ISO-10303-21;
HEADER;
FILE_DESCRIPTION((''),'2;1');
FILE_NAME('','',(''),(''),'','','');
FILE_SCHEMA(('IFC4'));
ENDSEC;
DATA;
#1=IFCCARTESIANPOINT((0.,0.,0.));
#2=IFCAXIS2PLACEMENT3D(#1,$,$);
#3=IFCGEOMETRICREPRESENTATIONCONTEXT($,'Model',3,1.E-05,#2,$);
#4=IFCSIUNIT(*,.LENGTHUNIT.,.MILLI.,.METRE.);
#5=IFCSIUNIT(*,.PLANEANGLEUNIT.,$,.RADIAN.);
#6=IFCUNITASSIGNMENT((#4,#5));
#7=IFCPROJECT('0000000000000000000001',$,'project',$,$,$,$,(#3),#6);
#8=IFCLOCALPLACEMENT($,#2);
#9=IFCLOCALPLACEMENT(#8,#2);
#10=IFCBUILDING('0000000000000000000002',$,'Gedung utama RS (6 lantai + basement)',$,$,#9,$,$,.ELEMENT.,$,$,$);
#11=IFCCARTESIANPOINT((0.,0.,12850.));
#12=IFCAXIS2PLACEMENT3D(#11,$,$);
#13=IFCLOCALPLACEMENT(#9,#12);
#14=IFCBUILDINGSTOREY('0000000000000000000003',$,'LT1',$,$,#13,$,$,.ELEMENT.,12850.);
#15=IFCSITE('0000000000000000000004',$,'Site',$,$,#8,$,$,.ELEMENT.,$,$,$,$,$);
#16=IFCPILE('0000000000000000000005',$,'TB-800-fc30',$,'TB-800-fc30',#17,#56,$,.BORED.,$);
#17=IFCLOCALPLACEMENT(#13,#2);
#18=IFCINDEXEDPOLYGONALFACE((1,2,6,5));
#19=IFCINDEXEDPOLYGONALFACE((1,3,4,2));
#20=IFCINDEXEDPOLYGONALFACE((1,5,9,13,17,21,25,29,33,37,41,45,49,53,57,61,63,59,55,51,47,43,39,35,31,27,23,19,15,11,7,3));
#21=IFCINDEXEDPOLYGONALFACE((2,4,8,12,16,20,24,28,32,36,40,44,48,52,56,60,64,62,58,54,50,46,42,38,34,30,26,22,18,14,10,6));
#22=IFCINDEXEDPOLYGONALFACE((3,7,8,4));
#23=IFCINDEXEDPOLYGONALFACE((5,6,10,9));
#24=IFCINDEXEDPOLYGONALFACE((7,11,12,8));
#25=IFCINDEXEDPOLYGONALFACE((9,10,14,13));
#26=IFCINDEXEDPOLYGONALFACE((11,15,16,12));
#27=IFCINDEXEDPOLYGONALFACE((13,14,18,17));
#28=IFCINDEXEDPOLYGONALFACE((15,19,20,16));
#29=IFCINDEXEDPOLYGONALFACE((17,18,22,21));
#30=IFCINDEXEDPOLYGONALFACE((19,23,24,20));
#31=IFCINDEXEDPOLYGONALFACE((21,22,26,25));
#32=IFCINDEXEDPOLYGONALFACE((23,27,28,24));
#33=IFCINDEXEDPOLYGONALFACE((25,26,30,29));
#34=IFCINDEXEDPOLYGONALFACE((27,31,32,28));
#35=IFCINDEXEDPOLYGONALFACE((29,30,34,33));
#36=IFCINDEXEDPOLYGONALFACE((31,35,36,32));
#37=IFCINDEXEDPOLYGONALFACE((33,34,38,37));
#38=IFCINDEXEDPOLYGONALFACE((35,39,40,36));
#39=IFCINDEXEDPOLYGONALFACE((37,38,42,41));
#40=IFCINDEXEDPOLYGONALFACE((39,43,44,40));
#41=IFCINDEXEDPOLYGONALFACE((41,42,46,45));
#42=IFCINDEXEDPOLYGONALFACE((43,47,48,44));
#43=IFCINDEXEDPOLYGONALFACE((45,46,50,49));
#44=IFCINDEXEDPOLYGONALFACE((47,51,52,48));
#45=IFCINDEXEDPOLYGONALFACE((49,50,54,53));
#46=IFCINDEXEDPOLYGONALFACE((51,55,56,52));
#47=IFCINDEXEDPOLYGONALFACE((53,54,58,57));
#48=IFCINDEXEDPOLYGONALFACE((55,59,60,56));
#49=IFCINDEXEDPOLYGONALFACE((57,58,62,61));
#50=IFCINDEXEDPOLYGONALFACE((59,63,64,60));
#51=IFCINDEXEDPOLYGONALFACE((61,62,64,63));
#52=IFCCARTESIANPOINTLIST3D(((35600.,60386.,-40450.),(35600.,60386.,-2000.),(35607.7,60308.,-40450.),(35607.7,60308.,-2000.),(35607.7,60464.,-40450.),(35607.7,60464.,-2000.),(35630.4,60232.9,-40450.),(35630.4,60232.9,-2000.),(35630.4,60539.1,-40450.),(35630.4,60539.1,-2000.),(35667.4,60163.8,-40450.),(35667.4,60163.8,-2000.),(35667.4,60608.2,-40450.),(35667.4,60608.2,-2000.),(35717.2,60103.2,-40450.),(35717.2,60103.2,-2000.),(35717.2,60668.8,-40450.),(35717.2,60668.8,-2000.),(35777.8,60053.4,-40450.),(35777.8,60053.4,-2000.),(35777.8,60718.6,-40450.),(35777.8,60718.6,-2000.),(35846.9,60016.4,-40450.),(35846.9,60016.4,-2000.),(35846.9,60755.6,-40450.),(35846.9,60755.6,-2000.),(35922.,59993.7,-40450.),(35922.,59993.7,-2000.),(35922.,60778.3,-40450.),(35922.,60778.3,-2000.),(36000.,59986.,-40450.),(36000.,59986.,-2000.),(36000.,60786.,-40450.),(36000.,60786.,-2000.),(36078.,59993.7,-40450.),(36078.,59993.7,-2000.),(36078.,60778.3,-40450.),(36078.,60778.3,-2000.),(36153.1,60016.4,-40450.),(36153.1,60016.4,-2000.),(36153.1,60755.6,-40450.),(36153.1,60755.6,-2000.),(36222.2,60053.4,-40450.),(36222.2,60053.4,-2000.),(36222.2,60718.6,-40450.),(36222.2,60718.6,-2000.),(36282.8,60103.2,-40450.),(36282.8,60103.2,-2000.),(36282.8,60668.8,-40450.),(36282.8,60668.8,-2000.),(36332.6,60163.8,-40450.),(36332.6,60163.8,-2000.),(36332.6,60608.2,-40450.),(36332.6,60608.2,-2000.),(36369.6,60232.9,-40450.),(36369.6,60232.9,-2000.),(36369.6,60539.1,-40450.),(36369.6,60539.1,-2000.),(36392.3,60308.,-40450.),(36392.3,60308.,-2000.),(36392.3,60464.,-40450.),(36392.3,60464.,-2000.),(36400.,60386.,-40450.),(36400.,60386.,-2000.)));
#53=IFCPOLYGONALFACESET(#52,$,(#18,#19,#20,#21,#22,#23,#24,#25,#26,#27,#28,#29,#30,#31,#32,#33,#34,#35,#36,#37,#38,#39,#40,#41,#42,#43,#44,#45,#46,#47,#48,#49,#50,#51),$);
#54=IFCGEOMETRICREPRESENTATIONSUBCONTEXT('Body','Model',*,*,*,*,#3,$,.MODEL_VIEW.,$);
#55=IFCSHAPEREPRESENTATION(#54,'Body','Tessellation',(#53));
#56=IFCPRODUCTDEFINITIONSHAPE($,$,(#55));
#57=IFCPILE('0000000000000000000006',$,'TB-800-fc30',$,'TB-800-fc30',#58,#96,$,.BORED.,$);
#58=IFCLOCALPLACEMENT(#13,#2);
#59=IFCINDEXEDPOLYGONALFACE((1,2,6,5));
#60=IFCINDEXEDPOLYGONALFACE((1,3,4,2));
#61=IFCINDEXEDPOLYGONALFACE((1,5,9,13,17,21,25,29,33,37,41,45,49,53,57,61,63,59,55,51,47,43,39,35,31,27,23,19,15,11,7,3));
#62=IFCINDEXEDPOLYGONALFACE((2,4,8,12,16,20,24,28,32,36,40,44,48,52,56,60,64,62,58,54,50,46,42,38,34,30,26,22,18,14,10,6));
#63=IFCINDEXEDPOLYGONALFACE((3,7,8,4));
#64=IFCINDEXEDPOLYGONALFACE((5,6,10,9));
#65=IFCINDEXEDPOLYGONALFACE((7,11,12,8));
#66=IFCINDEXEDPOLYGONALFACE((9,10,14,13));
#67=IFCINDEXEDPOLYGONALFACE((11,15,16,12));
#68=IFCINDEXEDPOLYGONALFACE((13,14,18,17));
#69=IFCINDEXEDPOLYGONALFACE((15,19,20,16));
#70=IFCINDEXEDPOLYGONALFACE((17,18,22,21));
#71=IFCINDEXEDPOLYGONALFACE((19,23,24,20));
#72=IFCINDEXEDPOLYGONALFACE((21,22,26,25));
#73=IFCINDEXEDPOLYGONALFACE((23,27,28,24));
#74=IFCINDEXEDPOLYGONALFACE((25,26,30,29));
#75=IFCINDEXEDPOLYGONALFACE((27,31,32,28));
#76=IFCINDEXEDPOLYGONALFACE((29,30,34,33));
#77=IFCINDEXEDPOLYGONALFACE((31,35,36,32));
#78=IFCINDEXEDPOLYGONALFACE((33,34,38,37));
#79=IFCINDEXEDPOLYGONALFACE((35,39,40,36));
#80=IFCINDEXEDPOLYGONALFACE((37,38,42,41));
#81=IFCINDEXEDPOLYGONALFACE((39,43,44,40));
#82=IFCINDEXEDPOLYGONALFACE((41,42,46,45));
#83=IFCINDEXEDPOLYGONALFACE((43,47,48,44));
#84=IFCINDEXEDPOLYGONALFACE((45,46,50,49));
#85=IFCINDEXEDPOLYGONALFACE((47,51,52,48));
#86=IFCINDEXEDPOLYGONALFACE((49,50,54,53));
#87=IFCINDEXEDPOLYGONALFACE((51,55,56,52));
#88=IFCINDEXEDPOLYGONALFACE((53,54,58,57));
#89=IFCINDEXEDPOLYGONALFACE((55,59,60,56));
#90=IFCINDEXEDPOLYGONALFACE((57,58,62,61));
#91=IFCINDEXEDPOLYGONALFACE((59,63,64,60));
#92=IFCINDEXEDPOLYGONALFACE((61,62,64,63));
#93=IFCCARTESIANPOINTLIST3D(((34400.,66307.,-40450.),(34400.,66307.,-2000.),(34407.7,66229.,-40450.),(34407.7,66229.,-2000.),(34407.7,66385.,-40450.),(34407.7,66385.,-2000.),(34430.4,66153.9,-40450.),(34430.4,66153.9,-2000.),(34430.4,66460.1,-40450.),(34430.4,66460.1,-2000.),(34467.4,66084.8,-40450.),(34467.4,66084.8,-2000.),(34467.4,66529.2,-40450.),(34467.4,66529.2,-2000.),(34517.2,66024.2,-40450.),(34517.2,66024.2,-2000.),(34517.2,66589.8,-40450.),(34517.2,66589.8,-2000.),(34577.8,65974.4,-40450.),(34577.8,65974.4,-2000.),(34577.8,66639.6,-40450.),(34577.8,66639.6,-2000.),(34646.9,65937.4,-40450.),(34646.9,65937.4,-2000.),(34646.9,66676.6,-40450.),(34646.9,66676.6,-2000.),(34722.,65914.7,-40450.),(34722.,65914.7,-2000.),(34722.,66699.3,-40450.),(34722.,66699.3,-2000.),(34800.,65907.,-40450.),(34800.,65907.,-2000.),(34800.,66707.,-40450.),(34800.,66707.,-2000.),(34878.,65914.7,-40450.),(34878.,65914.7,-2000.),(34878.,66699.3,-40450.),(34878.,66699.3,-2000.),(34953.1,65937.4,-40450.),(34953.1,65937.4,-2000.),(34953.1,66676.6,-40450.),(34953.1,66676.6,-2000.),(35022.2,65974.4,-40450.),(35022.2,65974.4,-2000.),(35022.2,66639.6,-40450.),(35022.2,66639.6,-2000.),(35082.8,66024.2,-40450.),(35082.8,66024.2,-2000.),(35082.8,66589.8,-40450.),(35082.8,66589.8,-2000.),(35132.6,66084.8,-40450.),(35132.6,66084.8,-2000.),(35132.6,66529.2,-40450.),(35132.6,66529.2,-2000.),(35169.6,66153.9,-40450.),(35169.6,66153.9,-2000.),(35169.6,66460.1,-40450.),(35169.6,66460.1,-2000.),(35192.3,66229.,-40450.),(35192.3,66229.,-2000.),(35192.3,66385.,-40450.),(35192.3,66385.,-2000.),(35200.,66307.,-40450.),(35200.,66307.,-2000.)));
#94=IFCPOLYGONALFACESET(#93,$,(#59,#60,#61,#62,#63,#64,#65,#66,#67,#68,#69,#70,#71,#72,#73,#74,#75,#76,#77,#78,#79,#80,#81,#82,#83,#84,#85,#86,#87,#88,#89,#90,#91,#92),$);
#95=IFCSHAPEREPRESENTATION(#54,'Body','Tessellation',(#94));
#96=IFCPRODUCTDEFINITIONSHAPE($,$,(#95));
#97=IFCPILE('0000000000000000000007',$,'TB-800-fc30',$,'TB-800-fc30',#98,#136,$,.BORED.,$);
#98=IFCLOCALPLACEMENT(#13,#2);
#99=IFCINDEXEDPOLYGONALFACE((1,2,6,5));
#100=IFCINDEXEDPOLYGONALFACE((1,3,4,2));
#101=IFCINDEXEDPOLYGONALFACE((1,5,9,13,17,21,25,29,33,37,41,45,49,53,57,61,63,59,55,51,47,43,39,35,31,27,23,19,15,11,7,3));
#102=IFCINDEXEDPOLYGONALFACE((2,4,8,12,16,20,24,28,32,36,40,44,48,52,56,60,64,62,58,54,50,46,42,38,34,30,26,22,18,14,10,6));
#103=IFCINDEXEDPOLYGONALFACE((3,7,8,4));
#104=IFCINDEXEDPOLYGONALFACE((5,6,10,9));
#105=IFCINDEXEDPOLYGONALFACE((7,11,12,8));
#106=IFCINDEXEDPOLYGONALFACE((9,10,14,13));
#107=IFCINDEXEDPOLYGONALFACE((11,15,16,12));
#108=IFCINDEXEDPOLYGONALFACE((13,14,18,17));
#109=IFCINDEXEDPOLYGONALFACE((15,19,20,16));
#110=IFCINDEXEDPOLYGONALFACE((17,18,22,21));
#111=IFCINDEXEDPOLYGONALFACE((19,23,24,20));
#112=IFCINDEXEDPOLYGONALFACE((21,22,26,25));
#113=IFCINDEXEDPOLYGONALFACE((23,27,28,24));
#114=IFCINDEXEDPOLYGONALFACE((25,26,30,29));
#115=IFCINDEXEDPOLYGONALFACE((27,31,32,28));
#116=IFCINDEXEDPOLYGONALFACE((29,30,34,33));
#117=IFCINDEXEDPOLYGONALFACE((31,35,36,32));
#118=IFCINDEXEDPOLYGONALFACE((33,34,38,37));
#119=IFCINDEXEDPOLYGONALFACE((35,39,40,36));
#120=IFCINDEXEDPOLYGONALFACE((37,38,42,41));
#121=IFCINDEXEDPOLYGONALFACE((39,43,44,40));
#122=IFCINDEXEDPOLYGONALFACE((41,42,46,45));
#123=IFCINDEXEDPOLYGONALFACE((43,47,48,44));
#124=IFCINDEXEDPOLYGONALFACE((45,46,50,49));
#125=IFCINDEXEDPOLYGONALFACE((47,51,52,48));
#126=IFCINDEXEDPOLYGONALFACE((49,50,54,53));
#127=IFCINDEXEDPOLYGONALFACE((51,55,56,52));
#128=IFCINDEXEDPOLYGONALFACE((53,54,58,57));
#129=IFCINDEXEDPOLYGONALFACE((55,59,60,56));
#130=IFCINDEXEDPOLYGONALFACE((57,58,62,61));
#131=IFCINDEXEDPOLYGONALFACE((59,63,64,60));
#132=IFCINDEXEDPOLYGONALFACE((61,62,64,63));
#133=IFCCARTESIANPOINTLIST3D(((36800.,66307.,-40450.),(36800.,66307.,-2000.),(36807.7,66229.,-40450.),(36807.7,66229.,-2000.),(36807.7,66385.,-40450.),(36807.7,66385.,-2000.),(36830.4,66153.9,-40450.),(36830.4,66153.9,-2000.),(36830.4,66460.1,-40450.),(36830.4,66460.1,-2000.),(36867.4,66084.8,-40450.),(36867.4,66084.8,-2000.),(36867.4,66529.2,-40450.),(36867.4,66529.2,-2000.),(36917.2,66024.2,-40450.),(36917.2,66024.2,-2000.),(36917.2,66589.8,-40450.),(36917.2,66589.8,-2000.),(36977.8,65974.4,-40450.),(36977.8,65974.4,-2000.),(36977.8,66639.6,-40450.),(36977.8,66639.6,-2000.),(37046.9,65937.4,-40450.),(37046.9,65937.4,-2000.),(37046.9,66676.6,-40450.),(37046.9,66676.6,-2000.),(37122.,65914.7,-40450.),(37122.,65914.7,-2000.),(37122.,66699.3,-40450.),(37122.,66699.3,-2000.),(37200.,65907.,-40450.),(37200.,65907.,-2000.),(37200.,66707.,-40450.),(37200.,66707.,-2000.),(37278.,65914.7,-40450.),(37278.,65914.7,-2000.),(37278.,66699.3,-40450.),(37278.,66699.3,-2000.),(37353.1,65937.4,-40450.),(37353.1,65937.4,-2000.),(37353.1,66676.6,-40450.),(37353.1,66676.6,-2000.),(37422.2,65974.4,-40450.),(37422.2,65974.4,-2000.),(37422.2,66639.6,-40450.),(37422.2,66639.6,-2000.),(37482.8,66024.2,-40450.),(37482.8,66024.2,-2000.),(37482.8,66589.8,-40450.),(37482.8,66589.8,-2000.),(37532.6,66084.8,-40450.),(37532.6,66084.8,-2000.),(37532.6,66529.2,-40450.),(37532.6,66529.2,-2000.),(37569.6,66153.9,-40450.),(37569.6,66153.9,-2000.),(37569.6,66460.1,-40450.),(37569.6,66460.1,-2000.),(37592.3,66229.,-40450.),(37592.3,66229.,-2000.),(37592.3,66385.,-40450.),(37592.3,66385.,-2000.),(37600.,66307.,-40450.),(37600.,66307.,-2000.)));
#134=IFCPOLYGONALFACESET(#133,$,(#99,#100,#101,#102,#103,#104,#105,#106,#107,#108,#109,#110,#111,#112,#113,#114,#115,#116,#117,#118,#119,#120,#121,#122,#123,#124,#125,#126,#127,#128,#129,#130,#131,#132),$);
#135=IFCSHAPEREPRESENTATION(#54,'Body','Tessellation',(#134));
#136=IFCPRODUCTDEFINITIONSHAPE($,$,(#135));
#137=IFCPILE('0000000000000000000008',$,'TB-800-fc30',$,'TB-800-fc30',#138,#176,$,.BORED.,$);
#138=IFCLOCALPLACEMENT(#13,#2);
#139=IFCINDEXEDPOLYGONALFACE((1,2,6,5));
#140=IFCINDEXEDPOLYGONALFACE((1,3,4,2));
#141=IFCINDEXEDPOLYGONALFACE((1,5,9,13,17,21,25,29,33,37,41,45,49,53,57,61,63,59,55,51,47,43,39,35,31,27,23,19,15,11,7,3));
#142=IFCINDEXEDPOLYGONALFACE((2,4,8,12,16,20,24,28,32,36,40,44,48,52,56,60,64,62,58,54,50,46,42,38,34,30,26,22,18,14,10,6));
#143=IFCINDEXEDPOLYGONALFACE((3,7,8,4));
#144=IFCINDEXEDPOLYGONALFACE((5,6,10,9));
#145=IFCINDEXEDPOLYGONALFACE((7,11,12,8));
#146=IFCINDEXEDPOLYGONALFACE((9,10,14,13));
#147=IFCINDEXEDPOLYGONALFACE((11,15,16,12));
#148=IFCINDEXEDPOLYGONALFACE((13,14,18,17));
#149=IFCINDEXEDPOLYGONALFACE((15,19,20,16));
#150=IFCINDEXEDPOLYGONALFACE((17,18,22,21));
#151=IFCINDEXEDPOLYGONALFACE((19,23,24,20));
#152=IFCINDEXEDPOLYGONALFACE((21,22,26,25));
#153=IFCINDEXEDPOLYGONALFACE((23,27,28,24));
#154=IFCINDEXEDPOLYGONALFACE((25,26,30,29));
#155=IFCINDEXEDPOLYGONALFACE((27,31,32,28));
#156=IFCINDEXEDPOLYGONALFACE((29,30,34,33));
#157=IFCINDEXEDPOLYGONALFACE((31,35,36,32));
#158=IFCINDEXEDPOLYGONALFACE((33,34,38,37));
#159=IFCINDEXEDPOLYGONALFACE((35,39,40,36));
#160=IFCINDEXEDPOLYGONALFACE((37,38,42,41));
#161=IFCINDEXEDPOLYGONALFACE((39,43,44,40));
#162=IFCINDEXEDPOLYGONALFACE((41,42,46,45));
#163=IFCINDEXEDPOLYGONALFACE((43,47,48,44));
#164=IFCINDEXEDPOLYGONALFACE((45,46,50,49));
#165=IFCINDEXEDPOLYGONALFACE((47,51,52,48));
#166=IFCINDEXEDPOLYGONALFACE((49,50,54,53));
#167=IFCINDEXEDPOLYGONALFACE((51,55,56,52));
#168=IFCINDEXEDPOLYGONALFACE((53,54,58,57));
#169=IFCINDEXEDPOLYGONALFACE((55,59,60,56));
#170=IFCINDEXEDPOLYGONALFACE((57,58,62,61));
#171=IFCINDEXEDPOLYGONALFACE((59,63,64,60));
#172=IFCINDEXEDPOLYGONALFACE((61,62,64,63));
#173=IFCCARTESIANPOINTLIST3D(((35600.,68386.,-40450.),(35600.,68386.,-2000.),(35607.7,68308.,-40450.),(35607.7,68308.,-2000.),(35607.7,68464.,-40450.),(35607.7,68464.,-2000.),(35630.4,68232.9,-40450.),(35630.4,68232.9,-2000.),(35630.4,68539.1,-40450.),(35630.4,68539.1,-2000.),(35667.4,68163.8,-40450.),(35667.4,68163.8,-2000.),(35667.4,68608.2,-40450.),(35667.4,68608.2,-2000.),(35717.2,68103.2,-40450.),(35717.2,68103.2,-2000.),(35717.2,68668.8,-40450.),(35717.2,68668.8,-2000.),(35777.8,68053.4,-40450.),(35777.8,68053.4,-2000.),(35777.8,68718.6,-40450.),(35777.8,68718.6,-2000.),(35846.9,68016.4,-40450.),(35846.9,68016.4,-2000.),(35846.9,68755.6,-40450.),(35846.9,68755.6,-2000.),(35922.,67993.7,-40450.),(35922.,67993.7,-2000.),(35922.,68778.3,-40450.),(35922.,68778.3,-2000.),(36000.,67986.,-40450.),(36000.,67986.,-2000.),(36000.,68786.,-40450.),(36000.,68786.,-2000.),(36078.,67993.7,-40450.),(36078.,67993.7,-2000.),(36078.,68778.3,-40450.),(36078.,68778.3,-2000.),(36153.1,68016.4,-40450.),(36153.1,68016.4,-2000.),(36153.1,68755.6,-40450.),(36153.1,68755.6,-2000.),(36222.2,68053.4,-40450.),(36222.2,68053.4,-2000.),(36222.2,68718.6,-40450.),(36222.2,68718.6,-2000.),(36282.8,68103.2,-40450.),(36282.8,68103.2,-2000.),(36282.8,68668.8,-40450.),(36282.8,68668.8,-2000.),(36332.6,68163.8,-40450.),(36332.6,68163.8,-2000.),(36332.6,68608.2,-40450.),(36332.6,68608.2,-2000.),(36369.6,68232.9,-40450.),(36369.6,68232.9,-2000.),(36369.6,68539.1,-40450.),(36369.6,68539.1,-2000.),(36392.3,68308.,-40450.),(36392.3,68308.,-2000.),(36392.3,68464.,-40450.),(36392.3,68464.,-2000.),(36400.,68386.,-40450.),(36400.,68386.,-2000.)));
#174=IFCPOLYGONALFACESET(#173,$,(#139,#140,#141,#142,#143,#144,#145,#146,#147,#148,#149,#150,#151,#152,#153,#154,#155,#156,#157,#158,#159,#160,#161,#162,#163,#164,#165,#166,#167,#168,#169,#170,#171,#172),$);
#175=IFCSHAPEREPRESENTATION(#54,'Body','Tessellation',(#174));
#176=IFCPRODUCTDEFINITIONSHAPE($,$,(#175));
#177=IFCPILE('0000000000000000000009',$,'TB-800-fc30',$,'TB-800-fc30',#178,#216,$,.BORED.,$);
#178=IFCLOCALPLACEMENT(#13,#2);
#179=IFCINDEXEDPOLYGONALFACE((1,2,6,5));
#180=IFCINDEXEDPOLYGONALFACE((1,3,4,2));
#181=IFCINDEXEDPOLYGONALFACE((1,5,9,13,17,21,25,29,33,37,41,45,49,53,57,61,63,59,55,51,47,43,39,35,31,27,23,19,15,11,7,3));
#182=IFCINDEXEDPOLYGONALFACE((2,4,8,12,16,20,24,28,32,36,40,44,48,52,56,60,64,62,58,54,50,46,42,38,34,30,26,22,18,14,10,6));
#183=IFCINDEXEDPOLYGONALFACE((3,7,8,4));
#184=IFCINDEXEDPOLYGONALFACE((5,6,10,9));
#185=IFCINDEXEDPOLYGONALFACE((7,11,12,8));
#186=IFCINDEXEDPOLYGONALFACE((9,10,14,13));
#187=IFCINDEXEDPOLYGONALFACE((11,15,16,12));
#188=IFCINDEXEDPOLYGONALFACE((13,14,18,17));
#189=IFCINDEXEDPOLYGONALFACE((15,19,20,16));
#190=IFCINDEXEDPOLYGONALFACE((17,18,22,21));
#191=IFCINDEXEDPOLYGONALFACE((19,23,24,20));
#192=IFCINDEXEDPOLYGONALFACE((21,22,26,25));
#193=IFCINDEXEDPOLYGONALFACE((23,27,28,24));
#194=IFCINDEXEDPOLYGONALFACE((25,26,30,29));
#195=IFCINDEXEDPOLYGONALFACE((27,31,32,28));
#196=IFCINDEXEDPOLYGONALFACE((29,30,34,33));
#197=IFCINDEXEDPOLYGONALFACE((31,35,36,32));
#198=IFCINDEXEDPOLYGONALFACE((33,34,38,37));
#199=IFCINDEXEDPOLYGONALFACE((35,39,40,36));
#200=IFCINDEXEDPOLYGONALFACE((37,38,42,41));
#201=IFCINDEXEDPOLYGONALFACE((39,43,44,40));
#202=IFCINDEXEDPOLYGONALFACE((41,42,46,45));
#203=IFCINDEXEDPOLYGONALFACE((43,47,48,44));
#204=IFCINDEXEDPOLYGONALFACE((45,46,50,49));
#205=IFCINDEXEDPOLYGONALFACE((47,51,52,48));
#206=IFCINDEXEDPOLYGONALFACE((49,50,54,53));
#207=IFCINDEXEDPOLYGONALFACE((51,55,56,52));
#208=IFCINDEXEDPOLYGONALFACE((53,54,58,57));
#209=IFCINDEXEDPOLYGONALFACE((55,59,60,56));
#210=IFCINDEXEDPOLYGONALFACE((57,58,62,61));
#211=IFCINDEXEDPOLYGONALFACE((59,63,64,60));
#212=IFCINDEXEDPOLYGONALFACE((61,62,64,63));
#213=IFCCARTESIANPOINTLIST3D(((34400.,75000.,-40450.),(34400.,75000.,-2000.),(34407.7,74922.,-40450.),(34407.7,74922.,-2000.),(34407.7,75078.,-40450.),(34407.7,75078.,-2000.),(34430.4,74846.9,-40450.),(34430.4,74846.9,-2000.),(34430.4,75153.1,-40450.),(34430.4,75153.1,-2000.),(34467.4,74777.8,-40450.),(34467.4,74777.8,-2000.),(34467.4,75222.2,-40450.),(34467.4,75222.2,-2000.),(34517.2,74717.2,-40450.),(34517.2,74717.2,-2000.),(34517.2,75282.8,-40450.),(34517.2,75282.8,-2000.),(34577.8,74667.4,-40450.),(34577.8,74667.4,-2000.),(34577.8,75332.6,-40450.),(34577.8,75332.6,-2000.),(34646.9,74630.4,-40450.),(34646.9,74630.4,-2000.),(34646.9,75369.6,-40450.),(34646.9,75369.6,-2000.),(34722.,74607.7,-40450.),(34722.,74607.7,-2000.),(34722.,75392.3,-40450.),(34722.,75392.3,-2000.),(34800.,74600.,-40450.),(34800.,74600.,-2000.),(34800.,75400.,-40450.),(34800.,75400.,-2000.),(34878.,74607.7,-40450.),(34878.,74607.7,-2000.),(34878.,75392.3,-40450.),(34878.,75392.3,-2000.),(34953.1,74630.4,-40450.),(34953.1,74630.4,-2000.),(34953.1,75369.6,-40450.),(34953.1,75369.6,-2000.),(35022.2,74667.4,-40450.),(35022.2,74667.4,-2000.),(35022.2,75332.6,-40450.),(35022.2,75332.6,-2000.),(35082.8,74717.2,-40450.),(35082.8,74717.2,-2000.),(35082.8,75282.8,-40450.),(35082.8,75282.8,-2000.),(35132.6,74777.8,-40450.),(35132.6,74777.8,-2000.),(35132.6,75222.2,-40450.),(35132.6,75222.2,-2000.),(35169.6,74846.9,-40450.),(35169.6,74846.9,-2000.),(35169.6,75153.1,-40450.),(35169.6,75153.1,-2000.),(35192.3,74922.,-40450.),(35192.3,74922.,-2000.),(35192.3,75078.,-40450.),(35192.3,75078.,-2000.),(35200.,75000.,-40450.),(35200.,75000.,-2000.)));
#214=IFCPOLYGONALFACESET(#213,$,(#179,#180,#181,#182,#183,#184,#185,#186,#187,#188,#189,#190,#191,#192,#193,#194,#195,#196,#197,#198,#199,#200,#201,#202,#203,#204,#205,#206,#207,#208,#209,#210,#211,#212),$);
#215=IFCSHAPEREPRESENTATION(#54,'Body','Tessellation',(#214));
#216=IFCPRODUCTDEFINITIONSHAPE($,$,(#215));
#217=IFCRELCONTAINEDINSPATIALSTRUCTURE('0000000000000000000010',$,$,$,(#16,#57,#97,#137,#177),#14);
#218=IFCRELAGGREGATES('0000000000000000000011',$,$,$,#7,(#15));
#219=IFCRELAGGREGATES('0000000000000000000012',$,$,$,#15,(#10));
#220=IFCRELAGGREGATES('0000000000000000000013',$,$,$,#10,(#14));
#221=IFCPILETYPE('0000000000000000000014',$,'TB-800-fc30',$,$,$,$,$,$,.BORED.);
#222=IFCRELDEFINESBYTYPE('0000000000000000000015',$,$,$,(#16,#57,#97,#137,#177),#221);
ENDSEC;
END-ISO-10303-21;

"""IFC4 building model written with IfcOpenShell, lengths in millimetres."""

from ifc_helpers import new_model, si_unit, frame, origin, origin_2d, place, context, subcontext, project, spatial, circle, extrude, material_profile, profile_set, profile_usage, type_object, element, save


model = new_model("IFC4")

# Units and contexts
model_context = context("Model", 3, precision=1e-05, world=origin())
body_context = subcontext(model_context, "Body", "Model", "MODEL_VIEW")
ifc_project = project(units=[si_unit("LENGTHUNIT", "METRE", prefix="MILLI"), si_unit("PLANEANGLEUNIT", "RADIAN")], contexts=[model_context])

# Site, building, storey
site_placement = place(None, origin())
site = spatial("IfcSite", under=ifc_project, at=site_placement, Name="Site", CompositionType="ELEMENT")
building_placement = place(site_placement, origin())
building = spatial("IfcBuilding", under=site, at=building_placement, Name="Gedung utama RS (6 lantai + basement)", CompositionType="ELEMENT")
storey_placement = place(building_placement, frame((0.0, 0.0, 12850.0)))
storey = spatial("IfcBuildingStorey", under=building, at=storey_placement, Name="LT1", CompositionType="ELEMENT", Elevation=12850.0)

# Piles
ifc_material_profile = material_profile(None, circle(Radius=400.0, at=origin_2d()), Name="TB-800-fc30")
ifc_profile_set = profile_set([ifc_material_profile], Name="TB-800-fc30")
ifc_profile_usage = profile_usage(ifc_profile_set, cardinal=5)
pile_type = type_object("IfcPileType", Name="TB-800-fc30", PredefinedType="BORED", material=ifc_profile_set)
for number, where, z_axis, x_axis, name in (
    (1, (36000.0, 60386.0, -40450.0), (0.0, 0.0, 1.0), (1.0, 0.0, 0.0), "TB-800-fc30"),
    (2, (34800.0, 66307.0, -40450.0), (0.0, 0.0, 1.0), (1.0, 0.0, 0.0), "TB-800-fc30"),
    (3, (37200.0, 66307.0, -40450.0), (0.0, 0.0, 1.0), (1.0, 0.0, 0.0), "TB-800-fc30"),
    (4, (36000.0, 68386.0, -40450.0), (0.0, 0.0, 1.0), (1.0, 0.0, 0.0), "TB-800-fc30"),
    (5, (34800.0, 75000.0, -40450.0), (0.0, 0.0, 1.0), (1.0, 0.0, 0.0), "TB-800-fc30"),
):
    element("IfcPile", number, at=place(storey_placement, frame(where, z_axis=z_axis, x_axis=x_axis)), inside=storey, type_object=pile_type, material=ifc_profile_usage, Name=name, ObjectType="TB-800-fc30", PredefinedType="BORED", context=body_context, shape_type="SweptSolid", body=[
        extrude(circle(Radius=400.0, at=origin_2d()), origin(), (0.0, 0.0, 1.0), 38450.0),
    ])

save(model, "model.ifc")
